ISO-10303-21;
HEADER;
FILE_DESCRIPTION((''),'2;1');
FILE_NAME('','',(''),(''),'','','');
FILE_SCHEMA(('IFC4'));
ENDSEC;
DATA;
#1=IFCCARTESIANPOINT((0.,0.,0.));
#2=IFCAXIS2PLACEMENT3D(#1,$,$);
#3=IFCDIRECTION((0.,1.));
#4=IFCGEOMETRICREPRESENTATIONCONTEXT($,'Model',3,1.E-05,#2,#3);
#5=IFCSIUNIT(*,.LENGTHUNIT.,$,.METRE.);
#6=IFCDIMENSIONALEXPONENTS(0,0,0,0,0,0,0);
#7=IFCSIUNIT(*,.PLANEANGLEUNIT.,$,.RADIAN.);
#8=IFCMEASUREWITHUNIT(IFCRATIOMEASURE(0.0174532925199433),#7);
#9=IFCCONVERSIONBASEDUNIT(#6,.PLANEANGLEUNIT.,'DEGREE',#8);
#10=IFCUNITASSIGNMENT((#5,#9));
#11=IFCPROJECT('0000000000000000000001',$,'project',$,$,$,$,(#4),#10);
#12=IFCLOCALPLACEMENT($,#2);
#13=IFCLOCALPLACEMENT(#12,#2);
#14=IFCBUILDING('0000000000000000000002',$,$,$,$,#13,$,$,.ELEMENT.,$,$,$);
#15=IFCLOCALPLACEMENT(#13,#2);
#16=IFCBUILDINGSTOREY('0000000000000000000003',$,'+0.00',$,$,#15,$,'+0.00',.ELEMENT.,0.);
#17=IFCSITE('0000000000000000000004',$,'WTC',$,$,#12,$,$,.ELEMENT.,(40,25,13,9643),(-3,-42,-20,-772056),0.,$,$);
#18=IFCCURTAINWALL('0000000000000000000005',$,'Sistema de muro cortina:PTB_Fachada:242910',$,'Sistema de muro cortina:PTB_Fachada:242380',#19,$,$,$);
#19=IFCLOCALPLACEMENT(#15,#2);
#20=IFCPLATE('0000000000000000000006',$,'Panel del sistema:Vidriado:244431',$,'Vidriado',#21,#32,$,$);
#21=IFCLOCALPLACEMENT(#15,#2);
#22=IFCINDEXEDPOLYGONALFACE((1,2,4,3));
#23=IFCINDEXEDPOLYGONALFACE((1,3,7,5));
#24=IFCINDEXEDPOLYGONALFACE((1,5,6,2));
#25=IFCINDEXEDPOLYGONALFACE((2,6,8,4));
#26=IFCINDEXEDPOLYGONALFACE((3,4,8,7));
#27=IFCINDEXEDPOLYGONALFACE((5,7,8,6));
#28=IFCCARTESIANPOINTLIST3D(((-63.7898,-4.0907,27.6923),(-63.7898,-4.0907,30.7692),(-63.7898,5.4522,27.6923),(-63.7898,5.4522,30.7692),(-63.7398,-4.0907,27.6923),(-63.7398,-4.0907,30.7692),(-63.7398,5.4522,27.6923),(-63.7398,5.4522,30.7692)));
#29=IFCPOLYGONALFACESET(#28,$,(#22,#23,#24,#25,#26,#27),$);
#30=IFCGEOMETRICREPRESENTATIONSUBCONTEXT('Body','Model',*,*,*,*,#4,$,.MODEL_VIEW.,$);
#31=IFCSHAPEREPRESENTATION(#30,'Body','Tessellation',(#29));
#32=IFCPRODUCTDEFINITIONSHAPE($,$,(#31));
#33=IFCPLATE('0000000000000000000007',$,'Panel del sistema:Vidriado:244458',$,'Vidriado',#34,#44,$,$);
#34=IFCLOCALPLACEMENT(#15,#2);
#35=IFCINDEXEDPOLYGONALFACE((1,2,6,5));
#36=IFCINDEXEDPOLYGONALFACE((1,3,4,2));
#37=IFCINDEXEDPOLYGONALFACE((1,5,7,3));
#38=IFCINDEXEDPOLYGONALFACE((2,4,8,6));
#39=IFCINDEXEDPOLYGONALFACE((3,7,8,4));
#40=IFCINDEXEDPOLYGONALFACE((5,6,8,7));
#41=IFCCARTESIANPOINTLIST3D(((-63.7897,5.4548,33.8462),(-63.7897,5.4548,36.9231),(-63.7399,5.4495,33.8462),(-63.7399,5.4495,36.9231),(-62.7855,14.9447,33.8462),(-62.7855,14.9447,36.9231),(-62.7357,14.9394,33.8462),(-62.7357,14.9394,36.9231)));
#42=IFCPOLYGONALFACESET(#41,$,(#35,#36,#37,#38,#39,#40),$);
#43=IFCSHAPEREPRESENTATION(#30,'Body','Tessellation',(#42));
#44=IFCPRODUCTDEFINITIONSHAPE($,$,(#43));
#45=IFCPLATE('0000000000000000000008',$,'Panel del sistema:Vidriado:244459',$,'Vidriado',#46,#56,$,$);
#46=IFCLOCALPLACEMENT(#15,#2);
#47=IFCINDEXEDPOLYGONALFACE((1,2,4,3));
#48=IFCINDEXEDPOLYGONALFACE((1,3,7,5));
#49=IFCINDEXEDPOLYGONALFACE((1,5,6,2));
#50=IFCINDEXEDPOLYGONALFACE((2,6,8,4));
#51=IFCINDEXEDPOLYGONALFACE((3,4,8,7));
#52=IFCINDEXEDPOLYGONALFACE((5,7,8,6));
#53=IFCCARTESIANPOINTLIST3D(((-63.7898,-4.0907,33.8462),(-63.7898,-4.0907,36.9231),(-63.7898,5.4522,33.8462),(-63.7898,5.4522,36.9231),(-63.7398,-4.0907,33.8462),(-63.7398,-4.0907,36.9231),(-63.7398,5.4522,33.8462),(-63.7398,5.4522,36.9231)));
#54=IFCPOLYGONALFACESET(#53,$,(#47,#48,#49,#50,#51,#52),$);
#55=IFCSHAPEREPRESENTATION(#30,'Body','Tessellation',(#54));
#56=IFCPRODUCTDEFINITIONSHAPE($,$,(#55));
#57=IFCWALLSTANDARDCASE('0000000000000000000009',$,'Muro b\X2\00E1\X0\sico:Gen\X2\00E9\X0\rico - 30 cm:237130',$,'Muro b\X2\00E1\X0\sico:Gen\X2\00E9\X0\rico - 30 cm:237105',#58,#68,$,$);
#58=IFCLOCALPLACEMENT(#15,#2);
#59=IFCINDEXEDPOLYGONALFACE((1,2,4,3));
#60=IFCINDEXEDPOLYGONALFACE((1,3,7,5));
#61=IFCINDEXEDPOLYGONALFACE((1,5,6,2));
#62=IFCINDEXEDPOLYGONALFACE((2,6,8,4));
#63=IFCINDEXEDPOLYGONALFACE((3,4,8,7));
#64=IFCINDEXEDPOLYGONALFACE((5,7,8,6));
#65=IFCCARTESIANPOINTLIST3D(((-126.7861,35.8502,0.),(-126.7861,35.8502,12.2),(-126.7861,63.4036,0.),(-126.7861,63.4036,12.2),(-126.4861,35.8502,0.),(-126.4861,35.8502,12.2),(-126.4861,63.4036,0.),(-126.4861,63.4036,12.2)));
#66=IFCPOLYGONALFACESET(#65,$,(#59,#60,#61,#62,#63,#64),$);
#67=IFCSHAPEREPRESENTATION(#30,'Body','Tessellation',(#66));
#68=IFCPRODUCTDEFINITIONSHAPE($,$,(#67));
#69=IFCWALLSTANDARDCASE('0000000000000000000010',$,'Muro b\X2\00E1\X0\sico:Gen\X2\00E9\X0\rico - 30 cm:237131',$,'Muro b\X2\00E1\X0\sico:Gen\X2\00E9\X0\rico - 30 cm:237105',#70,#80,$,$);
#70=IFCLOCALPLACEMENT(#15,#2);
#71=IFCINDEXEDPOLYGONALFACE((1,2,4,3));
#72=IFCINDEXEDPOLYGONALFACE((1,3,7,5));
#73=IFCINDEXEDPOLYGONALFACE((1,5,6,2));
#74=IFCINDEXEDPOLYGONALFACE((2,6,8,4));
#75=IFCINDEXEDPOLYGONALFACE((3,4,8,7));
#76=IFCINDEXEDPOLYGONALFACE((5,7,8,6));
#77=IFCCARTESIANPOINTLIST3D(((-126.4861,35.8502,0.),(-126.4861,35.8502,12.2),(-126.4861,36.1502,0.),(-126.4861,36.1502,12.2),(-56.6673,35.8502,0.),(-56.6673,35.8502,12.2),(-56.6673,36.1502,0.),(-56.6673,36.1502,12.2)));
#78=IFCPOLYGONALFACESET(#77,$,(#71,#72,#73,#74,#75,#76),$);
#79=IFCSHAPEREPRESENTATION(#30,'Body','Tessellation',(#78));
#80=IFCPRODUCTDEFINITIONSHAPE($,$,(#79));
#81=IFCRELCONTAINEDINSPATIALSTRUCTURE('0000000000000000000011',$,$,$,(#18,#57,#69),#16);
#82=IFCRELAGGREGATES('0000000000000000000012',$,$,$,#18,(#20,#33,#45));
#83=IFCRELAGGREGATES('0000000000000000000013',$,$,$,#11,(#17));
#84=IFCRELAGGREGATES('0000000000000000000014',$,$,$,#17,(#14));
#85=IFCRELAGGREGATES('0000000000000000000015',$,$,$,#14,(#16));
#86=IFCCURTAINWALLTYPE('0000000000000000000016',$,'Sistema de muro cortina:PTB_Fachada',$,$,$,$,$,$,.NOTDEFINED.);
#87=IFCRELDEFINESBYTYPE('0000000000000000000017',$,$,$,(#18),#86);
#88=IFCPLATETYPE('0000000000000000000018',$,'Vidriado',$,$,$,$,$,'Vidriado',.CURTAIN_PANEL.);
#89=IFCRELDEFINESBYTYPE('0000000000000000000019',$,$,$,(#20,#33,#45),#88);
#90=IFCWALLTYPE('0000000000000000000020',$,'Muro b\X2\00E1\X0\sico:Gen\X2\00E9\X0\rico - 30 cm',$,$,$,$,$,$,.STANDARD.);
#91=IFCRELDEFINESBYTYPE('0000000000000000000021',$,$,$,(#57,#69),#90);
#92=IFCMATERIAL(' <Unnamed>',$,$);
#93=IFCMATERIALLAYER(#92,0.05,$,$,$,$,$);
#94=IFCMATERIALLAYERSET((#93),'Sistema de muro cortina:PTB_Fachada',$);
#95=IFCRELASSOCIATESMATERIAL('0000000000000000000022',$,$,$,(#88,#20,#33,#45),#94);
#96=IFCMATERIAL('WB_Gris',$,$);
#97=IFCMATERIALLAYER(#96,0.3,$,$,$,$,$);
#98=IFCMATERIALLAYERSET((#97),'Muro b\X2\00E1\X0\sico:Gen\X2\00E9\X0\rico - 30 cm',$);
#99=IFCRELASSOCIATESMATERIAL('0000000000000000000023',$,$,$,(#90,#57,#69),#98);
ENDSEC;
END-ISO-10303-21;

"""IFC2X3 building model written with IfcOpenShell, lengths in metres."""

from ifc_helpers import new_model, entity, si_unit, converted_unit, direction, frame, frame_2d, origin, origin_2d_with_axis, place, context, subcontext, project, spatial, polyline, rectangle, extrude, clip, bounded_halfspace, source, transform, mapped, material, layer, layer_set, layer_usage, type_object, type_shapes, element, aggregate, save


model = new_model("IFC2X3")

# Units and contexts
model_context = context("Model", 3, precision=1e-05, world=origin(), true_north=direction((0.0, 1.0)))
body_context = subcontext(model_context, "Body", "Model", "MODEL_VIEW")
ifc_project = project(units=[si_unit("LENGTHUNIT", "METRE"), converted_unit("PLANEANGLEUNIT", "DEGREE", entity("IfcRatioMeasure", 0.0174532925199433), si_unit("PLANEANGLEUNIT", "RADIAN"), dimensions=[0, 0, 0, 0, 0, 0, 0])], contexts=[model_context])

# Site, building, storey
site_placement = place(None, origin())
site = spatial("IfcSite", under=ifc_project, at=site_placement, Name="WTC", CompositionType="ELEMENT", RefLatitude=(40, 25, 13, 9643), RefLongitude=(-3, -42, -20, -772056), RefElevation=0.0)
building_placement = place(site_placement, origin())
building = spatial("IfcBuilding", under=site, at=building_placement, CompositionType="ELEMENT")
storey_placement = place(building_placement, origin())
storey = spatial("IfcBuildingStorey", under=building, at=storey_placement, Name="+0.00", LongName="+0.00", CompositionType="ELEMENT", Elevation=0.0)

# Curtain wall, plates
curtain_wall_type = type_object("IfcCurtainWallType", Name="Sistema de muro cortina:PTB_Fachada", PredefinedType="NOTDEFINED")
curtain_wall_placement = place(storey_placement, origin())
curtain_wall = element("IfcCurtainWall", 1, at=curtain_wall_placement, inside=storey, type_object=curtain_wall_type, Name="Sistema de muro cortina:PTB_Fachada:242910", ObjectType="Sistema de muro cortina:PTB_Fachada:242380")
ifc_material_1 = material(Name=" <Unnamed>")
ifc_layer_1 = layer(ifc_material_1, 0.05)
ifc_layer_set_1 = layer_set([ifc_layer_1], Name="Sistema de muro cortina:PTB_Fachada")
plate_type_1 = type_object("IfcPlateType", Name="Vidriado", ElementType="Vidriado", PredefinedType="CURTAIN_PANEL", material=ifc_layer_set_1)
shared_shape_1 = source(origin(), body_context, "Body", "SweptSolid", [
    extrude(rectangle(XDim=0.05, YDim=9.5428, at=origin_2d_with_axis()), frame((0.0, 0.0, 0.0), z_axis=(0.0, 0.0, 1.0), x_axis=(0.0, 1.0, 0.0)), (0.0, 0.0, 1.0), 3.0769),
])
type_shapes(plate_type_1, [shared_shape_1])
ifc_layer_usage_1 = layer_usage(ifc_layer_set_1, "AXIS3", "POSITIVE", 0.0)
plate_1_placement = place(curtain_wall_placement, frame((-63.7648, 0.6808, 27.6923), z_axis=(0.0, 0.0, 1.0), x_axis=(0.0, -1.0, 0.0)))
plate_1 = element("IfcPlate", 2, at=plate_1_placement, type_object=plate_type_1, material=ifc_layer_usage_1, Name="Panel del sistema:Vidriado:244431", ObjectType="Vidriado", context=body_context, shape_type="MappedRepresentation", body=[
    mapped(shared_shape_1, transform((0.0, 0.0, 0.0), scale=1.0)),
])
ifc_layer_usage_2 = layer_usage(ifc_layer_set_1, "AXIS3", "POSITIVE", 0.0)
plate_2_placement = place(curtain_wall_placement, frame((-63.2627, 10.1971, 33.8462), z_axis=(0.0, 0.0, 1.0), x_axis=(-0.105232, -0.994448, 0.0)))
plate_2 = element("IfcPlate", 3, at=plate_2_placement, type_object=plate_type_1, material=ifc_layer_usage_2, Name="Panel del sistema:Vidriado:244458", ObjectType="Vidriado", context=body_context, shape_type="MappedRepresentation", body=[
    mapped(shared_shape_1, transform((0.0, 0.0, 0.0), scale=1.0)),
])
ifc_layer_usage_3 = layer_usage(ifc_layer_set_1, "AXIS3", "POSITIVE", 0.0)
plate_3_placement = place(curtain_wall_placement, frame((-63.7648, 0.6808, 33.8462), z_axis=(0.0, 0.0, 1.0), x_axis=(0.0, -1.0, 0.0)))
plate_3 = element("IfcPlate", 4, at=plate_3_placement, type_object=plate_type_1, material=ifc_layer_usage_3, Name="Panel del sistema:Vidriado:244459", ObjectType="Vidriado", context=body_context, shape_type="MappedRepresentation", body=[
    mapped(shared_shape_1, transform((0.0, 0.0, 0.0), scale=1.0)),
])
aggregate(curtain_wall, [plate_1, plate_2, plate_3])

# Walls
ifc_material_2 = material(Name="WB_Gris")
ifc_layer_2 = layer(ifc_material_2, 0.3)
ifc_layer_set_2 = layer_set([ifc_layer_2], Name="Muro básico:Genérico - 30 cm")
ifc_layer_usage_4 = layer_usage(ifc_layer_set_2, "AXIS2", "POSITIVE", -0.15)
wall_type = type_object("IfcWallType", Name="Muro básico:Genérico - 30 cm", PredefinedType="STANDARD", material=ifc_layer_set_2)
wall_1_placement = place(storey_placement, frame((-126.6361, 63.4036, 0.0), z_axis=(0.0, 0.0, 1.0), x_axis=(0.0, -1.0, 0.0)))
element("IfcWallStandardCase", 5, at=wall_1_placement, inside=storey, type_object=wall_type, material=ifc_layer_usage_4, Name="Muro básico:Genérico - 30 cm:237130", ObjectType="Muro básico:Genérico - 30 cm:237105", context=body_context, shape_type="Clipping", body=[
    clip(extrude(rectangle(XDim=27.5533, YDim=0.3, at=frame_2d((13.7767, 0.0), x_axis=(-1.0, 0.0))), origin(), (0.0, 0.0, 1.0), 12.2), bounded_halfspace(frame((0.0, -0.15, 12.2)), False, frame((0.0, -0.15, 12.2)), polyline([(0.0, 0.0), (27.5533, 0.0), (27.5533, 0.3), (27.2533, 0.3), (0.0, 0.3), (0.0, 0.0)]))),
])
ifc_layer_usage_5 = layer_usage(ifc_layer_set_2, "AXIS2", "POSITIVE", -0.15)
wall_2_placement = place(storey_placement, frame((-126.4861, 36.0002, 0.0)))
element("IfcWallStandardCase", 6, at=wall_2_placement, inside=storey, type_object=wall_type, material=ifc_layer_usage_5, Name="Muro básico:Genérico - 30 cm:237131", ObjectType="Muro básico:Genérico - 30 cm:237105", context=body_context, shape_type="Clipping", body=[
    clip(extrude(rectangle(XDim=69.8188, YDim=0.3, at=frame_2d((34.9094, 0.0), x_axis=(-1.0, 0.0))), origin(), (0.0, 0.0, 1.0), 12.2), bounded_halfspace(frame((0.0, -0.15, 12.2), z_axis=(0.0, 0.0, 1.0), x_axis=(0.0, -1.0, 0.0)), False, frame((0.0, -0.15, 12.2), z_axis=(0.0, 0.0, 1.0), x_axis=(0.0, -1.0, 0.0)), polyline([(0.0, 0.0), (0.0, 69.8188), (-0.3, 69.8188), (-0.3, 0.0), (0.0, 0.0)]))),
])

save(model, "model.ifc")
